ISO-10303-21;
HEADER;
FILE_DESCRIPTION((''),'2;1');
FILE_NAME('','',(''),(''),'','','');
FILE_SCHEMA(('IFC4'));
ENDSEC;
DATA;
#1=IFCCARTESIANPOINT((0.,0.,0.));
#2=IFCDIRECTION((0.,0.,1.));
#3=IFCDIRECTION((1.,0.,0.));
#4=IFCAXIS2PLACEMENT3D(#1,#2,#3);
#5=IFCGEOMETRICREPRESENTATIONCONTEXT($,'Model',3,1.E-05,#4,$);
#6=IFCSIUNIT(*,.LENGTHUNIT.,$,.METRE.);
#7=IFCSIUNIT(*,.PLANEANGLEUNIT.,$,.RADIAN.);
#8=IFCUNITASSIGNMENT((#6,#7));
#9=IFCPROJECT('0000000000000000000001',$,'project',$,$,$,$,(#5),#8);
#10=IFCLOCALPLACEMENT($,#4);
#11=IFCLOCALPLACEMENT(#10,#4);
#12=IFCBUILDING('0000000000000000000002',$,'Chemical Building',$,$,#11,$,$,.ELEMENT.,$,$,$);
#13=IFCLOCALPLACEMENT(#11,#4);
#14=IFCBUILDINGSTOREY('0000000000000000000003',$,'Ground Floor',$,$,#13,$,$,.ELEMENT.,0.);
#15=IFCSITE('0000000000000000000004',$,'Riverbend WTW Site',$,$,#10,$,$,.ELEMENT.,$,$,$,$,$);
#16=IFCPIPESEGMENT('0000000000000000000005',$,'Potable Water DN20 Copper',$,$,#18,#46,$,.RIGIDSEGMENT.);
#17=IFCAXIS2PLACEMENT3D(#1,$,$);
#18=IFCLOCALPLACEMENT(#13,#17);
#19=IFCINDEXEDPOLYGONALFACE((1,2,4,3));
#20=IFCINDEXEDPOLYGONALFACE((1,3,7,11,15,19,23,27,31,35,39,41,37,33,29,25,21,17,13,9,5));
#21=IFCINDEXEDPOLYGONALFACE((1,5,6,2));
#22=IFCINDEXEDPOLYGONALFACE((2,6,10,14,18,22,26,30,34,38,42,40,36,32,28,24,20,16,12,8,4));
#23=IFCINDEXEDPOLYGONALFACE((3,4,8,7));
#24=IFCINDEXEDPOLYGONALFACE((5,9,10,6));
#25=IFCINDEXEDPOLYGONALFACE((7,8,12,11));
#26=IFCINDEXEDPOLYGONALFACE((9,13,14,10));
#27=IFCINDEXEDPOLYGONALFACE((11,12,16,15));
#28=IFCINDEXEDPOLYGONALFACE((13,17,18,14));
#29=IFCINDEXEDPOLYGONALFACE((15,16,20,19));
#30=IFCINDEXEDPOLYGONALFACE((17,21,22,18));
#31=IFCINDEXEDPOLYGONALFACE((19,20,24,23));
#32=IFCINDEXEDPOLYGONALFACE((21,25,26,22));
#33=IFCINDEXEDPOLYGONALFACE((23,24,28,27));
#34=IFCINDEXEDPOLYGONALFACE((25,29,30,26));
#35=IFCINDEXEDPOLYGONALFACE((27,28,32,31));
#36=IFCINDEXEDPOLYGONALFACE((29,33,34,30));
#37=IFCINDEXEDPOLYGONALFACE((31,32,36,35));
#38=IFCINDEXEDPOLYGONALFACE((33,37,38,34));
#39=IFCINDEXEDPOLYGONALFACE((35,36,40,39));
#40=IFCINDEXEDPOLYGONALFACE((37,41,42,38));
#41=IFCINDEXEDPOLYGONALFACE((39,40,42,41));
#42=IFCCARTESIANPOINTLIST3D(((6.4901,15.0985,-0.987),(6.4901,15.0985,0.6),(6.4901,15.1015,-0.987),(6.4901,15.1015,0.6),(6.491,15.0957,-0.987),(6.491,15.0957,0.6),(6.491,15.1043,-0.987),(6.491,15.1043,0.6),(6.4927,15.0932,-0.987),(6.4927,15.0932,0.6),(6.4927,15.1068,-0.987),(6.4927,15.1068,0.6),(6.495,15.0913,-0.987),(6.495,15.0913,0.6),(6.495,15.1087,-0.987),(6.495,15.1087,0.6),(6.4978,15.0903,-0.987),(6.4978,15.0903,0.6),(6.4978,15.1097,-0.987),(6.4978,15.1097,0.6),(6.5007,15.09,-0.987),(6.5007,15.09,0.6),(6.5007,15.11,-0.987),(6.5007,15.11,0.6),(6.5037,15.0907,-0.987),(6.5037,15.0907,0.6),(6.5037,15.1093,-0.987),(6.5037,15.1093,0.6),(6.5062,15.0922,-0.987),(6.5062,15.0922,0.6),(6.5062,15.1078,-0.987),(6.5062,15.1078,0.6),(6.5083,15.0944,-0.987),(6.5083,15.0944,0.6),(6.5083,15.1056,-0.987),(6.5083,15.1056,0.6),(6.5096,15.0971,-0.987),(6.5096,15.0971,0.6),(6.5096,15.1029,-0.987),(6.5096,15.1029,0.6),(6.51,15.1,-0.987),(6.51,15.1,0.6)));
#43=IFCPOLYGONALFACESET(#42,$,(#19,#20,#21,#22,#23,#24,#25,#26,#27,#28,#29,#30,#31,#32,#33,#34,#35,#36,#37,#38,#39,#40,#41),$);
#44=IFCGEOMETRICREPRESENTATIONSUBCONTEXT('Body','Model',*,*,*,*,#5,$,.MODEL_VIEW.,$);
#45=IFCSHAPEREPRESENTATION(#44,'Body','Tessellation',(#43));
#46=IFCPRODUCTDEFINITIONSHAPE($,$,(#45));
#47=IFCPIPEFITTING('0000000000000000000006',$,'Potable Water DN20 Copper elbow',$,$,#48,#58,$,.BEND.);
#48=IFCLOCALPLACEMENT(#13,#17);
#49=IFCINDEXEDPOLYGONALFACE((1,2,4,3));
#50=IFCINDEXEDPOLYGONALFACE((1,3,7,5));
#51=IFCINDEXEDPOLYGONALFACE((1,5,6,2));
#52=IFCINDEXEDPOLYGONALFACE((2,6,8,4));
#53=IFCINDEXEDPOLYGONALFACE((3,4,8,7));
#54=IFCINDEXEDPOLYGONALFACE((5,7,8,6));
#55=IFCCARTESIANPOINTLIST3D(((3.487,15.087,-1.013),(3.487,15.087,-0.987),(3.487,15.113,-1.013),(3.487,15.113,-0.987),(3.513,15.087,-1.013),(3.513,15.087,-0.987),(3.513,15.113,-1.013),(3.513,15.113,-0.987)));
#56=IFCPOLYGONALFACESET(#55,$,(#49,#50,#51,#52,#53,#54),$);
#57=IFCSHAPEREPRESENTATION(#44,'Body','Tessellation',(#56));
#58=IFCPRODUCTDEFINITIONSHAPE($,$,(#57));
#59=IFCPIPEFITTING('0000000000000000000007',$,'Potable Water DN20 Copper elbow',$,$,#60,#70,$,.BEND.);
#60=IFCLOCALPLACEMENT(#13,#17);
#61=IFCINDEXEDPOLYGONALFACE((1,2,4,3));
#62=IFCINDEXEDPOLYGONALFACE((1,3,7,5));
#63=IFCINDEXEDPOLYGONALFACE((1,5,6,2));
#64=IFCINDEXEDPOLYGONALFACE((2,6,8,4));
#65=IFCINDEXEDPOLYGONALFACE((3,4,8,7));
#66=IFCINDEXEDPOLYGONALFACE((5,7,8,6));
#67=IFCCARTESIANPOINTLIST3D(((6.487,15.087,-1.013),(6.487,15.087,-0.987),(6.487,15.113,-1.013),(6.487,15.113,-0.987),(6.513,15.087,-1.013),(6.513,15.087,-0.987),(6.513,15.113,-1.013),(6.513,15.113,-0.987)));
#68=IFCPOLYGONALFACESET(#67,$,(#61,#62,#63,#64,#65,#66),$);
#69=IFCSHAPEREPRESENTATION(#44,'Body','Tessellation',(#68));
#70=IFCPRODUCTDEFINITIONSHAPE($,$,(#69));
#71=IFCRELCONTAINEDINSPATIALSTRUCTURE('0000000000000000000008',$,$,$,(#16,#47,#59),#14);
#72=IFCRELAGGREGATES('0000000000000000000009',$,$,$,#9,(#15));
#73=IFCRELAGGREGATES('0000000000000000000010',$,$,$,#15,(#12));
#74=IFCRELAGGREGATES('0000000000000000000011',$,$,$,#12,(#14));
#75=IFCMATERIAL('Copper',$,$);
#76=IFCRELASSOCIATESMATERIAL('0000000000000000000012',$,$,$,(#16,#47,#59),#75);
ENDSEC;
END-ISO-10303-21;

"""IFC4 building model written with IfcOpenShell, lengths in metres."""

from ifc_helpers import new_model, si_unit, frame, origin_with_axes, origin_2d, place, context, subcontext, project, spatial, rectangle, circle, extrude, material, element, save


model = new_model("IFC4")

# Units and contexts
model_context = context("Model", 3, precision=1e-05, world=origin_with_axes())
body_context = subcontext(model_context, "Body", "Model", "MODEL_VIEW")
ifc_project = project(units=[si_unit("LENGTHUNIT", "METRE"), si_unit("PLANEANGLEUNIT", "RADIAN")], contexts=[model_context])

# Site, building, storey
site_placement = place(None, origin_with_axes())
site = spatial("IfcSite", under=ifc_project, at=site_placement, Name="Riverbend WTW Site", CompositionType="ELEMENT")
building_placement = place(site_placement, origin_with_axes())
building = spatial("IfcBuilding", under=site, at=building_placement, Name="Chemical Building", CompositionType="ELEMENT")
storey_placement = place(building_placement, origin_with_axes())
storey = spatial("IfcBuildingStorey", under=building, at=storey_placement, Name="Ground Floor", CompositionType="ELEMENT", Elevation=0.0)

# Shared definitions
ifc_material_1 = material(Name="Copper")

# Pipe segment
pipe_segment_1_placement = place(None, frame((6.5, 15.1, -0.987), z_axis=(0.0, 0.0, 1.0), x_axis=(1.0, 0.0, 0.0)))
element("IfcPipeSegment", 1, at=pipe_segment_1_placement, inside=storey, material=ifc_material_1, Name="Potable Water DN20 Copper", PredefinedType="RIGIDSEGMENT", context=body_context, shape_type="SweptSolid", body=[
    extrude(circle(Radius=0.01, at=origin_2d()), origin_with_axes(), (0.0, 0.0, 1.0), 1.587),
])

# Pipe fittings
for number, where, z_axis, x_axis, name in (
    (2, (3.5, 15.1, -1.0), (0.0, 0.0, 1.0), (1.0, 0.0, 0.0), "Potable Water DN20 Copper elbow"),
    (3, (6.5, 15.1, -1.0), (0.0, 0.0, 1.0), (1.0, 0.0, 0.0), "Potable Water DN20 Copper elbow"),
):
    element("IfcPipeFitting", number, at=place(None, frame(where, z_axis=z_axis, x_axis=x_axis)), inside=storey, material=ifc_material_1, Name=name, PredefinedType="BEND", context=body_context, shape_type="SweptSolid", body=[
        extrude(rectangle(XDim=0.026, YDim=0.026, at=origin_2d()), frame((0.0, 0.0, -0.013), z_axis=(0.0, 0.0, 1.0), x_axis=(1.0, 0.0, 0.0)), (0.0, 0.0, 1.0), 0.026),
    ])

save(model, "model.ifc")
